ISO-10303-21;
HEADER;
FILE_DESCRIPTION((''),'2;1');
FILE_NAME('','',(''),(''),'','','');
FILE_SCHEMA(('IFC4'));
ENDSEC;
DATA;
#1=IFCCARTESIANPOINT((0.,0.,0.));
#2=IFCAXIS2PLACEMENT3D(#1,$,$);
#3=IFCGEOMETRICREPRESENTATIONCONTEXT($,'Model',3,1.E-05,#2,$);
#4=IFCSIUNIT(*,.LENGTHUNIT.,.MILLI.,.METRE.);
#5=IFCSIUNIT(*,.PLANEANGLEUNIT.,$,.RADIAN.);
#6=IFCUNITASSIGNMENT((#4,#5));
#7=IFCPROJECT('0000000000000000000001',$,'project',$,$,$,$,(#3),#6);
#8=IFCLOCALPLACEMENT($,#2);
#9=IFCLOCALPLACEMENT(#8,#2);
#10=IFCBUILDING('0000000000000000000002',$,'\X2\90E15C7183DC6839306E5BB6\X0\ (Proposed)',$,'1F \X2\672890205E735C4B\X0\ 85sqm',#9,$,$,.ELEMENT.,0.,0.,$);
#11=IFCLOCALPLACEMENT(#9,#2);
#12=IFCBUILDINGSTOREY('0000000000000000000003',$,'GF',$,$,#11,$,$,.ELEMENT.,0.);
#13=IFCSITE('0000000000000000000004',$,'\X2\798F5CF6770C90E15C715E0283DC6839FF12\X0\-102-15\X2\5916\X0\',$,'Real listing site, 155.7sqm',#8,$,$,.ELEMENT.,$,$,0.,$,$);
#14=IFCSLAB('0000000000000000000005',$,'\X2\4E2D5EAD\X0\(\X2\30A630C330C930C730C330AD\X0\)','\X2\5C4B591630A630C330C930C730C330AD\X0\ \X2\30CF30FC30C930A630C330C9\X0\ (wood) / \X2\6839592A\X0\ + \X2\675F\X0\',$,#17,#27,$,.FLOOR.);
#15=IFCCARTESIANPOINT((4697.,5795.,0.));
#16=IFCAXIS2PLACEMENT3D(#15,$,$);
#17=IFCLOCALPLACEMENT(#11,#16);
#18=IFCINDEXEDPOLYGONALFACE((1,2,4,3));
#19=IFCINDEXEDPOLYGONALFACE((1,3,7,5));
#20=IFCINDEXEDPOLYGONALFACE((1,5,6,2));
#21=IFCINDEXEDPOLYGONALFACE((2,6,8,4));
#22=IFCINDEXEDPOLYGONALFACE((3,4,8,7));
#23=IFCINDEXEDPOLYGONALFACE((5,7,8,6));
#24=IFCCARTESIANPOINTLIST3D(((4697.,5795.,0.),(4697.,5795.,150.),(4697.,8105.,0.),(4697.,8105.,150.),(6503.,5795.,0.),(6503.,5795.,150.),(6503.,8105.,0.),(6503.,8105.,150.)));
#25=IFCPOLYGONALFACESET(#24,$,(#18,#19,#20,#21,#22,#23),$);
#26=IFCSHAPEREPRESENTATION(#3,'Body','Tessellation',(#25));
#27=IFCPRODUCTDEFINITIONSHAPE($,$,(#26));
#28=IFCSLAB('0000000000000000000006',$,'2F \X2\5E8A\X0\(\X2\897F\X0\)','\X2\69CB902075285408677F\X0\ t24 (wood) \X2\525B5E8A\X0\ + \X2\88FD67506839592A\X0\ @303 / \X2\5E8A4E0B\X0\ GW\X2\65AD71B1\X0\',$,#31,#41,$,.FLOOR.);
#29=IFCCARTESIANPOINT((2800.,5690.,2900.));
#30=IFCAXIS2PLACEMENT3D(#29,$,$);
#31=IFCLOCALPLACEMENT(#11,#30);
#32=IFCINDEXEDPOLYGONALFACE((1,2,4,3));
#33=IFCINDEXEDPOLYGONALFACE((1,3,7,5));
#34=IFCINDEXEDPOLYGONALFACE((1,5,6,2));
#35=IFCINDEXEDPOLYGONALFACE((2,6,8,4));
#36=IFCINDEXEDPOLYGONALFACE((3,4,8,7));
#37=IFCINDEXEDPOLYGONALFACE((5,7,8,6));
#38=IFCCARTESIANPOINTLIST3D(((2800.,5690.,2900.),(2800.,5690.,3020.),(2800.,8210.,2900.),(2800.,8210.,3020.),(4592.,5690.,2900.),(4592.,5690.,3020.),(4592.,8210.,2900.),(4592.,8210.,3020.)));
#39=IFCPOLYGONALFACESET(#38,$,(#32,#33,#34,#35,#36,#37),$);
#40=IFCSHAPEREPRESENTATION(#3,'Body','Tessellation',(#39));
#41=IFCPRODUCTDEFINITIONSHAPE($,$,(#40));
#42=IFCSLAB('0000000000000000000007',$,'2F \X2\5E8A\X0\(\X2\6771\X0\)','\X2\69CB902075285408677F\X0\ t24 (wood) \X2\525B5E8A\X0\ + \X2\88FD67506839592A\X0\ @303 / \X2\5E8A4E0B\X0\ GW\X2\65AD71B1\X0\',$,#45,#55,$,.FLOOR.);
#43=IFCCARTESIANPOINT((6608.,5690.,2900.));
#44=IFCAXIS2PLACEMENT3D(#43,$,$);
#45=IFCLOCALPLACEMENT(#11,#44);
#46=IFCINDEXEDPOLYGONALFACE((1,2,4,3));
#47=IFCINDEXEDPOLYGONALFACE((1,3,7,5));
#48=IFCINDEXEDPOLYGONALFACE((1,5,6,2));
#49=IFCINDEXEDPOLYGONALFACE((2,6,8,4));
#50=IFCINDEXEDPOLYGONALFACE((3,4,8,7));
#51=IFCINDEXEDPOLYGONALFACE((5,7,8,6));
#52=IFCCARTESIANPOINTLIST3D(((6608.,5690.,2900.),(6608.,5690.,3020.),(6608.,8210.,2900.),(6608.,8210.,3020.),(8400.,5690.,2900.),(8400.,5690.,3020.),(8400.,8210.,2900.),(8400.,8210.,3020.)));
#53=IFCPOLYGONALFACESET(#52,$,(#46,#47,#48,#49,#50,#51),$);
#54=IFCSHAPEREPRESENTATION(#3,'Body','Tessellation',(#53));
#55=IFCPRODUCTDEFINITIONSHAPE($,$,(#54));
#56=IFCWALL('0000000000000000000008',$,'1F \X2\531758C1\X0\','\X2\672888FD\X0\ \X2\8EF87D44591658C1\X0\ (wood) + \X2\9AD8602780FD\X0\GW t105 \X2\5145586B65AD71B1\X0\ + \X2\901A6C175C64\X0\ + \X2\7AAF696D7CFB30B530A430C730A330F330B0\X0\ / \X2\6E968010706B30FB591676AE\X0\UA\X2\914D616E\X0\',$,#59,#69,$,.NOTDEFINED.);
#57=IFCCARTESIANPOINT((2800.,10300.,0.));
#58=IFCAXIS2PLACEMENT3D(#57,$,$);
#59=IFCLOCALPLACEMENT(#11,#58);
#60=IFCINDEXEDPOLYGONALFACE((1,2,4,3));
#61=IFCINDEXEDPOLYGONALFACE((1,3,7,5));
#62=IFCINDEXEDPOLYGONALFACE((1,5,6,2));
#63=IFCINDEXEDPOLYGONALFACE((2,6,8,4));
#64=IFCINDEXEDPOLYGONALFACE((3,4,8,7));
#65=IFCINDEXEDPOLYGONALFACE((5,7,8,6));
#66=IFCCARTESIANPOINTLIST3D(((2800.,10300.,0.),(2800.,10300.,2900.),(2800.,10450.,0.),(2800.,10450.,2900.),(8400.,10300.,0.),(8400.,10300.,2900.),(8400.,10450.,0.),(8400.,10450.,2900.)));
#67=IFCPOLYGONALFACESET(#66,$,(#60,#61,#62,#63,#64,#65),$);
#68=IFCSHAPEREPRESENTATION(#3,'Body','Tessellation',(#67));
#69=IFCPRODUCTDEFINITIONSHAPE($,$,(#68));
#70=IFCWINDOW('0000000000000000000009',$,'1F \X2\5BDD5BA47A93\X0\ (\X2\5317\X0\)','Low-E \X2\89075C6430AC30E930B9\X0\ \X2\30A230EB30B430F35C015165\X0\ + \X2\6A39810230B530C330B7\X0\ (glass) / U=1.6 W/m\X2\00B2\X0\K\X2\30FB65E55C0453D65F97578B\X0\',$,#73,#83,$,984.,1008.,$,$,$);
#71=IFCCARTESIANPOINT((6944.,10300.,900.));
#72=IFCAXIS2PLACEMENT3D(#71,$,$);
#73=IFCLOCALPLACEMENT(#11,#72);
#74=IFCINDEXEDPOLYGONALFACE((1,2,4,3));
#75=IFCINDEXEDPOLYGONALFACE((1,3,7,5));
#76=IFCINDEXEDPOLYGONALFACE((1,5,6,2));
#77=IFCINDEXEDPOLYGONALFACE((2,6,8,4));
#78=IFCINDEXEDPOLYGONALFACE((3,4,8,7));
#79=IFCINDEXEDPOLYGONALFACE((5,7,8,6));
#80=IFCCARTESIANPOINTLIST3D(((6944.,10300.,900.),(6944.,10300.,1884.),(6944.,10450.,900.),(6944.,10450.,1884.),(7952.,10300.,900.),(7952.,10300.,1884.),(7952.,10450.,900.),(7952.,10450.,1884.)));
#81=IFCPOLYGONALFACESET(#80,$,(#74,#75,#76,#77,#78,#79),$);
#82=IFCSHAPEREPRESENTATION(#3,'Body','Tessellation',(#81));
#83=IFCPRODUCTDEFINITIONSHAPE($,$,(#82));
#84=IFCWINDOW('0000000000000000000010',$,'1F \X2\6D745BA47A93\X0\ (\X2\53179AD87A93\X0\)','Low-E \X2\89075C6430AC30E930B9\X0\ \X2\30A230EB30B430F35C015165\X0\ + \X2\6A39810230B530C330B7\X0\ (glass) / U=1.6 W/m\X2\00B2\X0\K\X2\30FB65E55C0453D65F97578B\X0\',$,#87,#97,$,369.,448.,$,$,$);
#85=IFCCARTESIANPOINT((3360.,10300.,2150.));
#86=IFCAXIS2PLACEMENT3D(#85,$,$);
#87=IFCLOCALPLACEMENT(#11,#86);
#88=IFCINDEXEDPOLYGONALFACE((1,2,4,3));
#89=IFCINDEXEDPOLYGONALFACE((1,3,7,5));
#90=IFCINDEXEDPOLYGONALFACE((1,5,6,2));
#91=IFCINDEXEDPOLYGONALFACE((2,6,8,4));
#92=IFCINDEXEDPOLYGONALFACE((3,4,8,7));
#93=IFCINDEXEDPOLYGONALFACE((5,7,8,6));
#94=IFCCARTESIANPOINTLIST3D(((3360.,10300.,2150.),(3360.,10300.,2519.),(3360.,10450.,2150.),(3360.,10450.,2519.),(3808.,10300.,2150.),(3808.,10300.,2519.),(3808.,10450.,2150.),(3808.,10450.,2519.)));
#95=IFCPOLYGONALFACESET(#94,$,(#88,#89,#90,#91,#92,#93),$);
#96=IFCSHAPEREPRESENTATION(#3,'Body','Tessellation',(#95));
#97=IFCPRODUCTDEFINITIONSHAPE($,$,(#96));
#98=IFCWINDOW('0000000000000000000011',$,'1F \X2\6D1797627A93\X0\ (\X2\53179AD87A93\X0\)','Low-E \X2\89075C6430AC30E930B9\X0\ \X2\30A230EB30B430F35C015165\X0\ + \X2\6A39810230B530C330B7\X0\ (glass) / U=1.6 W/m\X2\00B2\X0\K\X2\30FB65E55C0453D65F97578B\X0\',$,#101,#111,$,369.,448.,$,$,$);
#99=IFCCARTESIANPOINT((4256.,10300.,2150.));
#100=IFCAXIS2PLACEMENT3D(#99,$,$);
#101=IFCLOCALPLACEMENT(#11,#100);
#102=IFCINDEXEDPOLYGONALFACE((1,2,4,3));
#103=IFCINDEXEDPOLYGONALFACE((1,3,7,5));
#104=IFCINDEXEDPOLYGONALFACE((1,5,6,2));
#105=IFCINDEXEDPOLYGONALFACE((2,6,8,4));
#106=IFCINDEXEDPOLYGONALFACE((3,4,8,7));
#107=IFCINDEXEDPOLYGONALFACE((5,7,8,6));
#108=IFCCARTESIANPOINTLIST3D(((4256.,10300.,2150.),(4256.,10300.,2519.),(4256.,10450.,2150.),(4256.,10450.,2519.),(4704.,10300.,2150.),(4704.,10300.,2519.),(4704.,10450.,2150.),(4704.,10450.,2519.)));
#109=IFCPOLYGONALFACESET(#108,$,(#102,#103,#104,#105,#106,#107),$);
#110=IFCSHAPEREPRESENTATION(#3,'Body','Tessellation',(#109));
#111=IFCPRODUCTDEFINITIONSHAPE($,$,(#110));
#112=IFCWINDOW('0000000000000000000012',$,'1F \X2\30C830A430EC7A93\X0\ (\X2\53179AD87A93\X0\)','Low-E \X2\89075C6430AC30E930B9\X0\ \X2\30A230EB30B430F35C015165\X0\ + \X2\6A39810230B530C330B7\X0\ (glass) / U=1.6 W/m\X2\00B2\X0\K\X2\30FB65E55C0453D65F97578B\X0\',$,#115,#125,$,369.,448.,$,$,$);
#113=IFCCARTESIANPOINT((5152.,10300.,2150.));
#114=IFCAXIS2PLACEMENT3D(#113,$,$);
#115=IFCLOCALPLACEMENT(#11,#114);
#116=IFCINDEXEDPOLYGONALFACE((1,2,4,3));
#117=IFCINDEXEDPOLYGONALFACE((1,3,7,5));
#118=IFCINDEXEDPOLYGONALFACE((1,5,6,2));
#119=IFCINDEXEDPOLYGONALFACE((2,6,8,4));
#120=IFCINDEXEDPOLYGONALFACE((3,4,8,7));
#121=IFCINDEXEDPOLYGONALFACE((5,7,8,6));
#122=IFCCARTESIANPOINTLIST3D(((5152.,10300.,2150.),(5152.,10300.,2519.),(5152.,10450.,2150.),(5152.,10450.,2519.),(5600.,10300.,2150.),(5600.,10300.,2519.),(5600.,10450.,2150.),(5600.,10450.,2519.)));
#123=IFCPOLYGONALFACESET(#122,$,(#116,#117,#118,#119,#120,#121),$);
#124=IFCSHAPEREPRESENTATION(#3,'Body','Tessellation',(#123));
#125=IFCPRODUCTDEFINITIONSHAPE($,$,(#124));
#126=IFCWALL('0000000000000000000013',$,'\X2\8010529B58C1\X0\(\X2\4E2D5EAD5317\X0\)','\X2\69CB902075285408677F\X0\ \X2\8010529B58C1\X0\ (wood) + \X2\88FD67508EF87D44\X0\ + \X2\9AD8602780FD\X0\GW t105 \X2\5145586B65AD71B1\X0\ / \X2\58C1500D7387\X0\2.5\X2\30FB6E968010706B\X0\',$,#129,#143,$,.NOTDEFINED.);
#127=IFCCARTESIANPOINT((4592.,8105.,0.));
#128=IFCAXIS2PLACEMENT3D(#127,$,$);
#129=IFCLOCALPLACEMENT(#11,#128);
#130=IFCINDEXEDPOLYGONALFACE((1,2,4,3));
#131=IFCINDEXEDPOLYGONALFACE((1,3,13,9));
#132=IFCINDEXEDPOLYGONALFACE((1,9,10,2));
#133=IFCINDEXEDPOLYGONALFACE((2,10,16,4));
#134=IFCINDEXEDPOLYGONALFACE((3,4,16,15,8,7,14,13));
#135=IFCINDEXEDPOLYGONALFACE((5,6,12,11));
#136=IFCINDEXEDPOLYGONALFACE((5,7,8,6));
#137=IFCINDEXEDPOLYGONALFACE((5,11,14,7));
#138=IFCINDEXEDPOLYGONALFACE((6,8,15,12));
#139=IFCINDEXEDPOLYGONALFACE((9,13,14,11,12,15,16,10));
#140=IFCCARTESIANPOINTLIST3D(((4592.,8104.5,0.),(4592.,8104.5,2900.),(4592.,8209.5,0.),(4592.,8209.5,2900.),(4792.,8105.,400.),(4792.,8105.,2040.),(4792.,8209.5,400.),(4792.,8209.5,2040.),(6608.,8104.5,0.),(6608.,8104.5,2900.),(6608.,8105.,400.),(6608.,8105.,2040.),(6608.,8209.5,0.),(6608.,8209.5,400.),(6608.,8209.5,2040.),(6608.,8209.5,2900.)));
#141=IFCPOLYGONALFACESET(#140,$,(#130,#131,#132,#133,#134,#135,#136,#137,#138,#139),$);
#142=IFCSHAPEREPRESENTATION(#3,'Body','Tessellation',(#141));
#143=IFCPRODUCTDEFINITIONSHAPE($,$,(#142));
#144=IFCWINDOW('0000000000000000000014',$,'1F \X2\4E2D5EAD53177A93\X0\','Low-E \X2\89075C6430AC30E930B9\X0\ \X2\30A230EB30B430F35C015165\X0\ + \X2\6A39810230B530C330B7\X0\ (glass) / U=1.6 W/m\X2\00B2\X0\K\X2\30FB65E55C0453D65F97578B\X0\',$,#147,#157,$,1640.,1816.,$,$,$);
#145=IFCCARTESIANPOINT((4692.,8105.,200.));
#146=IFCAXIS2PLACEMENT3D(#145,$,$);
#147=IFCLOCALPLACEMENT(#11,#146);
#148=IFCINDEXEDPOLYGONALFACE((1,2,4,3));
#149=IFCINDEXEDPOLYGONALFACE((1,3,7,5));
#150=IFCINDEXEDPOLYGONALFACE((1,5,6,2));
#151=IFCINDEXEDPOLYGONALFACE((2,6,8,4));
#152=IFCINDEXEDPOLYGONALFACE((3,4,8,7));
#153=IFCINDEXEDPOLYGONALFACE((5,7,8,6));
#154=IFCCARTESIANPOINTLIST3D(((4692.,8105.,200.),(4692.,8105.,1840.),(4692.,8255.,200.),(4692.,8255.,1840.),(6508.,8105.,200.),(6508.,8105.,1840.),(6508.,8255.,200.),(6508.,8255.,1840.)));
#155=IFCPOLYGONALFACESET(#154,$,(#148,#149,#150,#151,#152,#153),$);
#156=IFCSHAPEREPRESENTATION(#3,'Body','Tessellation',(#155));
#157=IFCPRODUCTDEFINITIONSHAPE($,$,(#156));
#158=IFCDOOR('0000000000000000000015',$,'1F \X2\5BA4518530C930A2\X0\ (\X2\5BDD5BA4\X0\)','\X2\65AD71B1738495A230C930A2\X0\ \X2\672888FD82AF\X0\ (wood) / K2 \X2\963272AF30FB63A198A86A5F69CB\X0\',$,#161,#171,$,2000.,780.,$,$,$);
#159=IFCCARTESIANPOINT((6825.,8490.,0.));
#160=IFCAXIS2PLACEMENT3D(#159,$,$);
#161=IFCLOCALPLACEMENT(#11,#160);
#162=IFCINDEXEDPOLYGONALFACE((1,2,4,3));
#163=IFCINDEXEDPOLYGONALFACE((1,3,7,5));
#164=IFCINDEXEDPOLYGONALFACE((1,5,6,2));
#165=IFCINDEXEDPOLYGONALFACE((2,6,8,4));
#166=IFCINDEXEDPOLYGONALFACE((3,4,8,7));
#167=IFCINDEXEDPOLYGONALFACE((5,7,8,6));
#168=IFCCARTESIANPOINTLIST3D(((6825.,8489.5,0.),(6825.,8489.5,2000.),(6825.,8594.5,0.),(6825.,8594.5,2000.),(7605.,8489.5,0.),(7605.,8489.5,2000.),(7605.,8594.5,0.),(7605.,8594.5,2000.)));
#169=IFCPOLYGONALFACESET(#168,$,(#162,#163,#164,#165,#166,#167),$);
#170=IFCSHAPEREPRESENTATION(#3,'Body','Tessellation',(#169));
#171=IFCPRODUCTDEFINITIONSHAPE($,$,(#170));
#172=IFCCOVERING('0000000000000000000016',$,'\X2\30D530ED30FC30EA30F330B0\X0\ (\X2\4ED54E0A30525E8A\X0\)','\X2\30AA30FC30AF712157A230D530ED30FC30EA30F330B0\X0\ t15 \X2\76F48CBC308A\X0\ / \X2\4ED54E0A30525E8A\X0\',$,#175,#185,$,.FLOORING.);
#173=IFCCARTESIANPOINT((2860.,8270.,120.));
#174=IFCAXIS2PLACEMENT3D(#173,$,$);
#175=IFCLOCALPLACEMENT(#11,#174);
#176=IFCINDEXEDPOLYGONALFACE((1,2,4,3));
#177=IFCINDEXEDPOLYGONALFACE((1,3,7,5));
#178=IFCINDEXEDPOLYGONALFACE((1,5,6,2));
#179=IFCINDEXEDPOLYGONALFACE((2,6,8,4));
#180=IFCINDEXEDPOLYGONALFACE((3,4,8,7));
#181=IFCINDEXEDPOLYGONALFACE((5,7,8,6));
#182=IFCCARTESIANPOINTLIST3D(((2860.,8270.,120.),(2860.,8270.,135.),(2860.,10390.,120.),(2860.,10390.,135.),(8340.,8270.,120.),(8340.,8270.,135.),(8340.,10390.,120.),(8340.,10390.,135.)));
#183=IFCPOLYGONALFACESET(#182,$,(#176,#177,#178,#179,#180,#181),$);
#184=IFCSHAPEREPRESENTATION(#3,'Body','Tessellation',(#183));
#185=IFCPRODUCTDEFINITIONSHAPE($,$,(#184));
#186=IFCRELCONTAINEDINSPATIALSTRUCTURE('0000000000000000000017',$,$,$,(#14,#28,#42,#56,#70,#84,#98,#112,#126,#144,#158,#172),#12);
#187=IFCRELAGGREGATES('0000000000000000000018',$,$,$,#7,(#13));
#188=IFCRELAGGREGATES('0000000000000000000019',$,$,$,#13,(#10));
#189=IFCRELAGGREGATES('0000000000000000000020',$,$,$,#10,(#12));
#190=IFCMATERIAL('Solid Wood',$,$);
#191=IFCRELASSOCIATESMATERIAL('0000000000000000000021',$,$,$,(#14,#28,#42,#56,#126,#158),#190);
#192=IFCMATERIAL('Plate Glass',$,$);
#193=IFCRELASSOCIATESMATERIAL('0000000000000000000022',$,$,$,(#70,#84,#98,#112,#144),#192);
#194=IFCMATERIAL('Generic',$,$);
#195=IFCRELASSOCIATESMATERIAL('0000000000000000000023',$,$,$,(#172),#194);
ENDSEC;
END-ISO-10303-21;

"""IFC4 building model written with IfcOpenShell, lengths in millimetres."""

from ifc_helpers import new_model, si_unit, frame, frame_2d, origin, place, context, project, spatial, rectangle, extrude, material, element, fill, save


model = new_model("IFC4")

# Units and contexts
model_context = context("Model", 3, precision=1e-05, world=origin())
ifc_project = project(units=[si_unit("LENGTHUNIT", "METRE", prefix="MILLI"), si_unit("PLANEANGLEUNIT", "RADIAN")], contexts=[model_context])

# Site, building, storey
site_placement = place(None, origin())
site = spatial("IfcSite", under=ifc_project, at=site_placement, Name="福島県郡山市菜根２-102-15外", ObjectType="Real listing site, 155.7sqm", CompositionType="ELEMENT", RefElevation=0.0)
building_placement = place(site_placement, origin())
building = spatial("IfcBuilding", under=site, at=building_placement, Name="郡山菜根の家 (Proposed)", ObjectType="1F 木造平屋 85sqm", CompositionType="ELEMENT", ElevationOfRefHeight=0.0, ElevationOfTerrain=0.0)
storey_placement = place(building_placement, origin())
storey = spatial("IfcBuildingStorey", under=building, at=storey_placement, Name="GF", CompositionType="ELEMENT", Elevation=0.0)

# Slabs
ifc_material_1 = material(Name="Solid Wood")
slab_1_placement = place(storey_placement, frame((4697.0, 5795.0, 0.0)))
element("IfcSlab", 1, at=slab_1_placement, inside=storey, material=ifc_material_1, Name="中庭(ウッドデッキ)", Description="屋外ウッドデッキ ハードウッド (wood) / 根太 + 束", PredefinedType="FLOOR", context=model_context, shape_type="SweptSolid", body=[
    extrude(rectangle(XDim=1806.0, YDim=2310.0, at=frame_2d((903.0, 1155.0))), frame((4697.0, 5795.0, 0.0)), (0.0, 0.0, 1.0), 150.0),
])
slab_2_placement = place(storey_placement, frame((2800.0, 5690.0, 2900.0)))
element("IfcSlab", 2, at=slab_2_placement, inside=storey, material=ifc_material_1, Name="2F 床(西)", Description="構造用合板 t24 (wood) 剛床 + 製材根太 @303 / 床下 GW断熱", PredefinedType="FLOOR", context=model_context, shape_type="SweptSolid", body=[
    extrude(rectangle(XDim=1792.0, YDim=2520.0, at=frame_2d((896.0, 1260.0))), frame((2800.0, 5690.0, 2900.0)), (0.0, 0.0, 1.0), 120.0),
])
slab_3_placement = place(storey_placement, frame((6608.0, 5690.0, 2900.0)))
element("IfcSlab", 3, at=slab_3_placement, inside=storey, material=ifc_material_1, Name="2F 床(東)", Description="構造用合板 t24 (wood) 剛床 + 製材根太 @303 / 床下 GW断熱", PredefinedType="FLOOR", context=model_context, shape_type="SweptSolid", body=[
    extrude(rectangle(XDim=1792.0, YDim=2520.0, at=frame_2d((896.0, 1260.0))), frame((6608.0, 5690.0, 2900.0)), (0.0, 0.0, 1.0), 120.0),
])

# Wall, openings, windows
wall_1_placement = place(storey_placement, frame((2800.0, 10300.0, 0.0)))
wall_1 = element("IfcWall", 4, at=wall_1_placement, inside=storey, material=ifc_material_1, Name="1F 北壁", Description="木製 軸組外壁 (wood) + 高性能GW t105 充填断熱 + 通気層 + 窯業系サイディング / 準耐火・外皮UA配慮", PredefinedType="NOTDEFINED", context=model_context, shape_type="SweptSolid", body=[
    extrude(rectangle(XDim=5600.0, YDim=150.0, at=frame_2d((2800.0, 75.0))), frame((2800.0, 10300.0, 0.0)), (0.0, 0.0, 1.0), 2900.0),
])
opening_1_placement = place(storey_placement, frame((6944.0, 10300.0, 900.0)))
opening_1 = element("IfcOpeningElement", 5, at=opening_1_placement, cuts=wall_1, PredefinedType="NOTDEFINED", context=model_context, shape_type="SweptSolid", body=[
    extrude(rectangle(XDim=1008.0, YDim=150.0, at=frame_2d((504.0, 75.0))), frame((6944.0, 10300.0, 900.0)), (0.0, 0.0, 1.0), 984.0),
])
opening_2_placement = place(storey_placement, frame((3360.0, 10300.0, 2150.0)))
opening_2 = element("IfcOpeningElement", 6, at=opening_2_placement, cuts=wall_1, PredefinedType="NOTDEFINED", context=model_context, shape_type="SweptSolid", body=[
    extrude(rectangle(XDim=448.0, YDim=150.0, at=frame_2d((224.0, 75.0))), frame((3360.0, 10300.0, 2150.0)), (0.0, 0.0, 1.0), 369.0),
])
opening_3_placement = place(storey_placement, frame((4256.0, 10300.0, 2150.0)))
opening_3 = element("IfcOpeningElement", 7, at=opening_3_placement, cuts=wall_1, PredefinedType="NOTDEFINED", context=model_context, shape_type="SweptSolid", body=[
    extrude(rectangle(XDim=448.0, YDim=150.0, at=frame_2d((224.0, 75.0))), frame((4256.0, 10300.0, 2150.0)), (0.0, 0.0, 1.0), 369.0),
])
opening_4_placement = place(storey_placement, frame((5152.0, 10300.0, 2150.0)))
opening_4 = element("IfcOpeningElement", 8, at=opening_4_placement, cuts=wall_1, PredefinedType="NOTDEFINED", context=model_context, shape_type="SweptSolid", body=[
    extrude(rectangle(XDim=448.0, YDim=150.0, at=frame_2d((224.0, 75.0))), frame((5152.0, 10300.0, 2150.0)), (0.0, 0.0, 1.0), 369.0),
])
ifc_material_2 = material(Name="Plate Glass")
window_1_placement = place(storey_placement, frame((6944.0, 10300.0, 900.0)))
window_1 = element("IfcWindow", 9, at=window_1_placement, inside=storey, material=ifc_material_2, Name="1F 寝室窓 (北)", Description="Low-E 複層ガラス アルゴン封入 + 樹脂サッシ (glass) / U=1.6 W/m²K・日射取得型", OverallHeight=984.0, OverallWidth=1008.0, context=model_context, shape_type="SweptSolid", body=[
    extrude(rectangle(XDim=1008.0, YDim=150.0, at=frame_2d((504.0, 75.0))), frame((6944.0, 10300.0, 900.0)), (0.0, 0.0, 1.0), 984.0),
])
fill(opening_1, window_1)
window_2_placement = place(storey_placement, frame((3360.0, 10300.0, 2150.0)))
window_2 = element("IfcWindow", 10, at=window_2_placement, inside=storey, material=ifc_material_2, Name="1F 浴室窓 (北高窓)", Description="Low-E 複層ガラス アルゴン封入 + 樹脂サッシ (glass) / U=1.6 W/m²K・日射取得型", OverallHeight=369.0, OverallWidth=448.0, context=model_context, shape_type="SweptSolid", body=[
    extrude(rectangle(XDim=448.0, YDim=150.0, at=frame_2d((224.0, 75.0))), frame((3360.0, 10300.0, 2150.0)), (0.0, 0.0, 1.0), 369.0),
])
fill(opening_2, window_2)
window_3_placement = place(storey_placement, frame((4256.0, 10300.0, 2150.0)))
window_3 = element("IfcWindow", 11, at=window_3_placement, inside=storey, material=ifc_material_2, Name="1F 洗面窓 (北高窓)", Description="Low-E 複層ガラス アルゴン封入 + 樹脂サッシ (glass) / U=1.6 W/m²K・日射取得型", OverallHeight=369.0, OverallWidth=448.0, context=model_context, shape_type="SweptSolid", body=[
    extrude(rectangle(XDim=448.0, YDim=150.0, at=frame_2d((224.0, 75.0))), frame((4256.0, 10300.0, 2150.0)), (0.0, 0.0, 1.0), 369.0),
])
fill(opening_3, window_3)
window_4_placement = place(storey_placement, frame((5152.0, 10300.0, 2150.0)))
window_4 = element("IfcWindow", 12, at=window_4_placement, inside=storey, material=ifc_material_2, Name="1F トイレ窓 (北高窓)", Description="Low-E 複層ガラス アルゴン封入 + 樹脂サッシ (glass) / U=1.6 W/m²K・日射取得型", OverallHeight=369.0, OverallWidth=448.0, context=model_context, shape_type="SweptSolid", body=[
    extrude(rectangle(XDim=448.0, YDim=150.0, at=frame_2d((224.0, 75.0))), frame((5152.0, 10300.0, 2150.0)), (0.0, 0.0, 1.0), 369.0),
])
fill(opening_4, window_4)

# Wall, opening, window
wall_2_placement = place(storey_placement, frame((4592.0, 8105.0, 0.0)))
wall_2 = element("IfcWall", 13, at=wall_2_placement, inside=storey, material=ifc_material_1, Name="耐力壁(中庭北)", Description="構造用合板 耐力壁 (wood) + 製材軸組 + 高性能GW t105 充填断熱 / 壁倍率2.5・準耐火", PredefinedType="NOTDEFINED", context=model_context, shape_type="SweptSolid", body=[
    extrude(rectangle(XDim=2016.0, YDim=105.0, at=frame_2d((1008.0, 52.0))), frame((4592.0, 8105.0, 0.0)), (0.0, 0.0, 1.0), 2900.0),
])
opening_5_placement = place(storey_placement, frame((4692.0, 8105.0, 200.0)))
opening_5 = element("IfcOpeningElement", 14, at=opening_5_placement, cuts=wall_2, PredefinedType="NOTDEFINED", context=model_context, shape_type="SweptSolid", body=[
    extrude(rectangle(XDim=1816.0, YDim=150.0, at=frame_2d((908.0, 75.0))), frame((4692.0, 8105.0, 200.0)), (0.0, 0.0, 1.0), 1640.0),
])
window_5_placement = place(storey_placement, frame((4692.0, 8105.0, 200.0)))
window_5 = element("IfcWindow", 15, at=window_5_placement, inside=storey, material=ifc_material_2, Name="1F 中庭北窓", Description="Low-E 複層ガラス アルゴン封入 + 樹脂サッシ (glass) / U=1.6 W/m²K・日射取得型", OverallHeight=1640.0, OverallWidth=1816.0, context=model_context, shape_type="SweptSolid", body=[
    extrude(rectangle(XDim=1816.0, YDim=150.0, at=frame_2d((908.0, 75.0))), frame((4692.0, 8105.0, 200.0)), (0.0, 0.0, 1.0), 1640.0),
])
fill(opening_5, window_5)

# Door
door_1_placement = place(storey_placement, frame((6825.0, 8490.0, 0.0)))
element("IfcDoor", 16, at=door_1_placement, inside=storey, material=ifc_material_1, Name="1F 室内ドア (寝室)", Description="断熱玄関ドア 木製芯 (wood) / K2 防犯・採風機構", OverallHeight=2000.0, OverallWidth=780.0, context=model_context, shape_type="SweptSolid", body=[
    extrude(rectangle(XDim=780.0, YDim=105.0, at=frame_2d((390.0, 52.0))), frame((6825.0, 8490.0, 0.0)), (0.0, 0.0, 1.0), 2000.0),
])

# Covering
ifc_material_3 = material(Name="Generic")
covering_1_placement = place(storey_placement, frame((2860.0, 8270.0, 120.0)))
element("IfcCovering", 17, at=covering_1_placement, inside=storey, material=ifc_material_3, Name="フローリング (仕上げ床)", Description="オーク無垢フローリング t15 直貼り / 仕上げ床", PredefinedType="FLOORING", context=model_context, shape_type="SweptSolid", body=[
    extrude(rectangle(XDim=5480.0, YDim=2120.0, at=frame_2d((2740.0, 1060.0))), frame((2860.0, 8270.0, 120.0)), (0.0, 0.0, 1.0), 15.0),
])

save(model, "model.ifc")
